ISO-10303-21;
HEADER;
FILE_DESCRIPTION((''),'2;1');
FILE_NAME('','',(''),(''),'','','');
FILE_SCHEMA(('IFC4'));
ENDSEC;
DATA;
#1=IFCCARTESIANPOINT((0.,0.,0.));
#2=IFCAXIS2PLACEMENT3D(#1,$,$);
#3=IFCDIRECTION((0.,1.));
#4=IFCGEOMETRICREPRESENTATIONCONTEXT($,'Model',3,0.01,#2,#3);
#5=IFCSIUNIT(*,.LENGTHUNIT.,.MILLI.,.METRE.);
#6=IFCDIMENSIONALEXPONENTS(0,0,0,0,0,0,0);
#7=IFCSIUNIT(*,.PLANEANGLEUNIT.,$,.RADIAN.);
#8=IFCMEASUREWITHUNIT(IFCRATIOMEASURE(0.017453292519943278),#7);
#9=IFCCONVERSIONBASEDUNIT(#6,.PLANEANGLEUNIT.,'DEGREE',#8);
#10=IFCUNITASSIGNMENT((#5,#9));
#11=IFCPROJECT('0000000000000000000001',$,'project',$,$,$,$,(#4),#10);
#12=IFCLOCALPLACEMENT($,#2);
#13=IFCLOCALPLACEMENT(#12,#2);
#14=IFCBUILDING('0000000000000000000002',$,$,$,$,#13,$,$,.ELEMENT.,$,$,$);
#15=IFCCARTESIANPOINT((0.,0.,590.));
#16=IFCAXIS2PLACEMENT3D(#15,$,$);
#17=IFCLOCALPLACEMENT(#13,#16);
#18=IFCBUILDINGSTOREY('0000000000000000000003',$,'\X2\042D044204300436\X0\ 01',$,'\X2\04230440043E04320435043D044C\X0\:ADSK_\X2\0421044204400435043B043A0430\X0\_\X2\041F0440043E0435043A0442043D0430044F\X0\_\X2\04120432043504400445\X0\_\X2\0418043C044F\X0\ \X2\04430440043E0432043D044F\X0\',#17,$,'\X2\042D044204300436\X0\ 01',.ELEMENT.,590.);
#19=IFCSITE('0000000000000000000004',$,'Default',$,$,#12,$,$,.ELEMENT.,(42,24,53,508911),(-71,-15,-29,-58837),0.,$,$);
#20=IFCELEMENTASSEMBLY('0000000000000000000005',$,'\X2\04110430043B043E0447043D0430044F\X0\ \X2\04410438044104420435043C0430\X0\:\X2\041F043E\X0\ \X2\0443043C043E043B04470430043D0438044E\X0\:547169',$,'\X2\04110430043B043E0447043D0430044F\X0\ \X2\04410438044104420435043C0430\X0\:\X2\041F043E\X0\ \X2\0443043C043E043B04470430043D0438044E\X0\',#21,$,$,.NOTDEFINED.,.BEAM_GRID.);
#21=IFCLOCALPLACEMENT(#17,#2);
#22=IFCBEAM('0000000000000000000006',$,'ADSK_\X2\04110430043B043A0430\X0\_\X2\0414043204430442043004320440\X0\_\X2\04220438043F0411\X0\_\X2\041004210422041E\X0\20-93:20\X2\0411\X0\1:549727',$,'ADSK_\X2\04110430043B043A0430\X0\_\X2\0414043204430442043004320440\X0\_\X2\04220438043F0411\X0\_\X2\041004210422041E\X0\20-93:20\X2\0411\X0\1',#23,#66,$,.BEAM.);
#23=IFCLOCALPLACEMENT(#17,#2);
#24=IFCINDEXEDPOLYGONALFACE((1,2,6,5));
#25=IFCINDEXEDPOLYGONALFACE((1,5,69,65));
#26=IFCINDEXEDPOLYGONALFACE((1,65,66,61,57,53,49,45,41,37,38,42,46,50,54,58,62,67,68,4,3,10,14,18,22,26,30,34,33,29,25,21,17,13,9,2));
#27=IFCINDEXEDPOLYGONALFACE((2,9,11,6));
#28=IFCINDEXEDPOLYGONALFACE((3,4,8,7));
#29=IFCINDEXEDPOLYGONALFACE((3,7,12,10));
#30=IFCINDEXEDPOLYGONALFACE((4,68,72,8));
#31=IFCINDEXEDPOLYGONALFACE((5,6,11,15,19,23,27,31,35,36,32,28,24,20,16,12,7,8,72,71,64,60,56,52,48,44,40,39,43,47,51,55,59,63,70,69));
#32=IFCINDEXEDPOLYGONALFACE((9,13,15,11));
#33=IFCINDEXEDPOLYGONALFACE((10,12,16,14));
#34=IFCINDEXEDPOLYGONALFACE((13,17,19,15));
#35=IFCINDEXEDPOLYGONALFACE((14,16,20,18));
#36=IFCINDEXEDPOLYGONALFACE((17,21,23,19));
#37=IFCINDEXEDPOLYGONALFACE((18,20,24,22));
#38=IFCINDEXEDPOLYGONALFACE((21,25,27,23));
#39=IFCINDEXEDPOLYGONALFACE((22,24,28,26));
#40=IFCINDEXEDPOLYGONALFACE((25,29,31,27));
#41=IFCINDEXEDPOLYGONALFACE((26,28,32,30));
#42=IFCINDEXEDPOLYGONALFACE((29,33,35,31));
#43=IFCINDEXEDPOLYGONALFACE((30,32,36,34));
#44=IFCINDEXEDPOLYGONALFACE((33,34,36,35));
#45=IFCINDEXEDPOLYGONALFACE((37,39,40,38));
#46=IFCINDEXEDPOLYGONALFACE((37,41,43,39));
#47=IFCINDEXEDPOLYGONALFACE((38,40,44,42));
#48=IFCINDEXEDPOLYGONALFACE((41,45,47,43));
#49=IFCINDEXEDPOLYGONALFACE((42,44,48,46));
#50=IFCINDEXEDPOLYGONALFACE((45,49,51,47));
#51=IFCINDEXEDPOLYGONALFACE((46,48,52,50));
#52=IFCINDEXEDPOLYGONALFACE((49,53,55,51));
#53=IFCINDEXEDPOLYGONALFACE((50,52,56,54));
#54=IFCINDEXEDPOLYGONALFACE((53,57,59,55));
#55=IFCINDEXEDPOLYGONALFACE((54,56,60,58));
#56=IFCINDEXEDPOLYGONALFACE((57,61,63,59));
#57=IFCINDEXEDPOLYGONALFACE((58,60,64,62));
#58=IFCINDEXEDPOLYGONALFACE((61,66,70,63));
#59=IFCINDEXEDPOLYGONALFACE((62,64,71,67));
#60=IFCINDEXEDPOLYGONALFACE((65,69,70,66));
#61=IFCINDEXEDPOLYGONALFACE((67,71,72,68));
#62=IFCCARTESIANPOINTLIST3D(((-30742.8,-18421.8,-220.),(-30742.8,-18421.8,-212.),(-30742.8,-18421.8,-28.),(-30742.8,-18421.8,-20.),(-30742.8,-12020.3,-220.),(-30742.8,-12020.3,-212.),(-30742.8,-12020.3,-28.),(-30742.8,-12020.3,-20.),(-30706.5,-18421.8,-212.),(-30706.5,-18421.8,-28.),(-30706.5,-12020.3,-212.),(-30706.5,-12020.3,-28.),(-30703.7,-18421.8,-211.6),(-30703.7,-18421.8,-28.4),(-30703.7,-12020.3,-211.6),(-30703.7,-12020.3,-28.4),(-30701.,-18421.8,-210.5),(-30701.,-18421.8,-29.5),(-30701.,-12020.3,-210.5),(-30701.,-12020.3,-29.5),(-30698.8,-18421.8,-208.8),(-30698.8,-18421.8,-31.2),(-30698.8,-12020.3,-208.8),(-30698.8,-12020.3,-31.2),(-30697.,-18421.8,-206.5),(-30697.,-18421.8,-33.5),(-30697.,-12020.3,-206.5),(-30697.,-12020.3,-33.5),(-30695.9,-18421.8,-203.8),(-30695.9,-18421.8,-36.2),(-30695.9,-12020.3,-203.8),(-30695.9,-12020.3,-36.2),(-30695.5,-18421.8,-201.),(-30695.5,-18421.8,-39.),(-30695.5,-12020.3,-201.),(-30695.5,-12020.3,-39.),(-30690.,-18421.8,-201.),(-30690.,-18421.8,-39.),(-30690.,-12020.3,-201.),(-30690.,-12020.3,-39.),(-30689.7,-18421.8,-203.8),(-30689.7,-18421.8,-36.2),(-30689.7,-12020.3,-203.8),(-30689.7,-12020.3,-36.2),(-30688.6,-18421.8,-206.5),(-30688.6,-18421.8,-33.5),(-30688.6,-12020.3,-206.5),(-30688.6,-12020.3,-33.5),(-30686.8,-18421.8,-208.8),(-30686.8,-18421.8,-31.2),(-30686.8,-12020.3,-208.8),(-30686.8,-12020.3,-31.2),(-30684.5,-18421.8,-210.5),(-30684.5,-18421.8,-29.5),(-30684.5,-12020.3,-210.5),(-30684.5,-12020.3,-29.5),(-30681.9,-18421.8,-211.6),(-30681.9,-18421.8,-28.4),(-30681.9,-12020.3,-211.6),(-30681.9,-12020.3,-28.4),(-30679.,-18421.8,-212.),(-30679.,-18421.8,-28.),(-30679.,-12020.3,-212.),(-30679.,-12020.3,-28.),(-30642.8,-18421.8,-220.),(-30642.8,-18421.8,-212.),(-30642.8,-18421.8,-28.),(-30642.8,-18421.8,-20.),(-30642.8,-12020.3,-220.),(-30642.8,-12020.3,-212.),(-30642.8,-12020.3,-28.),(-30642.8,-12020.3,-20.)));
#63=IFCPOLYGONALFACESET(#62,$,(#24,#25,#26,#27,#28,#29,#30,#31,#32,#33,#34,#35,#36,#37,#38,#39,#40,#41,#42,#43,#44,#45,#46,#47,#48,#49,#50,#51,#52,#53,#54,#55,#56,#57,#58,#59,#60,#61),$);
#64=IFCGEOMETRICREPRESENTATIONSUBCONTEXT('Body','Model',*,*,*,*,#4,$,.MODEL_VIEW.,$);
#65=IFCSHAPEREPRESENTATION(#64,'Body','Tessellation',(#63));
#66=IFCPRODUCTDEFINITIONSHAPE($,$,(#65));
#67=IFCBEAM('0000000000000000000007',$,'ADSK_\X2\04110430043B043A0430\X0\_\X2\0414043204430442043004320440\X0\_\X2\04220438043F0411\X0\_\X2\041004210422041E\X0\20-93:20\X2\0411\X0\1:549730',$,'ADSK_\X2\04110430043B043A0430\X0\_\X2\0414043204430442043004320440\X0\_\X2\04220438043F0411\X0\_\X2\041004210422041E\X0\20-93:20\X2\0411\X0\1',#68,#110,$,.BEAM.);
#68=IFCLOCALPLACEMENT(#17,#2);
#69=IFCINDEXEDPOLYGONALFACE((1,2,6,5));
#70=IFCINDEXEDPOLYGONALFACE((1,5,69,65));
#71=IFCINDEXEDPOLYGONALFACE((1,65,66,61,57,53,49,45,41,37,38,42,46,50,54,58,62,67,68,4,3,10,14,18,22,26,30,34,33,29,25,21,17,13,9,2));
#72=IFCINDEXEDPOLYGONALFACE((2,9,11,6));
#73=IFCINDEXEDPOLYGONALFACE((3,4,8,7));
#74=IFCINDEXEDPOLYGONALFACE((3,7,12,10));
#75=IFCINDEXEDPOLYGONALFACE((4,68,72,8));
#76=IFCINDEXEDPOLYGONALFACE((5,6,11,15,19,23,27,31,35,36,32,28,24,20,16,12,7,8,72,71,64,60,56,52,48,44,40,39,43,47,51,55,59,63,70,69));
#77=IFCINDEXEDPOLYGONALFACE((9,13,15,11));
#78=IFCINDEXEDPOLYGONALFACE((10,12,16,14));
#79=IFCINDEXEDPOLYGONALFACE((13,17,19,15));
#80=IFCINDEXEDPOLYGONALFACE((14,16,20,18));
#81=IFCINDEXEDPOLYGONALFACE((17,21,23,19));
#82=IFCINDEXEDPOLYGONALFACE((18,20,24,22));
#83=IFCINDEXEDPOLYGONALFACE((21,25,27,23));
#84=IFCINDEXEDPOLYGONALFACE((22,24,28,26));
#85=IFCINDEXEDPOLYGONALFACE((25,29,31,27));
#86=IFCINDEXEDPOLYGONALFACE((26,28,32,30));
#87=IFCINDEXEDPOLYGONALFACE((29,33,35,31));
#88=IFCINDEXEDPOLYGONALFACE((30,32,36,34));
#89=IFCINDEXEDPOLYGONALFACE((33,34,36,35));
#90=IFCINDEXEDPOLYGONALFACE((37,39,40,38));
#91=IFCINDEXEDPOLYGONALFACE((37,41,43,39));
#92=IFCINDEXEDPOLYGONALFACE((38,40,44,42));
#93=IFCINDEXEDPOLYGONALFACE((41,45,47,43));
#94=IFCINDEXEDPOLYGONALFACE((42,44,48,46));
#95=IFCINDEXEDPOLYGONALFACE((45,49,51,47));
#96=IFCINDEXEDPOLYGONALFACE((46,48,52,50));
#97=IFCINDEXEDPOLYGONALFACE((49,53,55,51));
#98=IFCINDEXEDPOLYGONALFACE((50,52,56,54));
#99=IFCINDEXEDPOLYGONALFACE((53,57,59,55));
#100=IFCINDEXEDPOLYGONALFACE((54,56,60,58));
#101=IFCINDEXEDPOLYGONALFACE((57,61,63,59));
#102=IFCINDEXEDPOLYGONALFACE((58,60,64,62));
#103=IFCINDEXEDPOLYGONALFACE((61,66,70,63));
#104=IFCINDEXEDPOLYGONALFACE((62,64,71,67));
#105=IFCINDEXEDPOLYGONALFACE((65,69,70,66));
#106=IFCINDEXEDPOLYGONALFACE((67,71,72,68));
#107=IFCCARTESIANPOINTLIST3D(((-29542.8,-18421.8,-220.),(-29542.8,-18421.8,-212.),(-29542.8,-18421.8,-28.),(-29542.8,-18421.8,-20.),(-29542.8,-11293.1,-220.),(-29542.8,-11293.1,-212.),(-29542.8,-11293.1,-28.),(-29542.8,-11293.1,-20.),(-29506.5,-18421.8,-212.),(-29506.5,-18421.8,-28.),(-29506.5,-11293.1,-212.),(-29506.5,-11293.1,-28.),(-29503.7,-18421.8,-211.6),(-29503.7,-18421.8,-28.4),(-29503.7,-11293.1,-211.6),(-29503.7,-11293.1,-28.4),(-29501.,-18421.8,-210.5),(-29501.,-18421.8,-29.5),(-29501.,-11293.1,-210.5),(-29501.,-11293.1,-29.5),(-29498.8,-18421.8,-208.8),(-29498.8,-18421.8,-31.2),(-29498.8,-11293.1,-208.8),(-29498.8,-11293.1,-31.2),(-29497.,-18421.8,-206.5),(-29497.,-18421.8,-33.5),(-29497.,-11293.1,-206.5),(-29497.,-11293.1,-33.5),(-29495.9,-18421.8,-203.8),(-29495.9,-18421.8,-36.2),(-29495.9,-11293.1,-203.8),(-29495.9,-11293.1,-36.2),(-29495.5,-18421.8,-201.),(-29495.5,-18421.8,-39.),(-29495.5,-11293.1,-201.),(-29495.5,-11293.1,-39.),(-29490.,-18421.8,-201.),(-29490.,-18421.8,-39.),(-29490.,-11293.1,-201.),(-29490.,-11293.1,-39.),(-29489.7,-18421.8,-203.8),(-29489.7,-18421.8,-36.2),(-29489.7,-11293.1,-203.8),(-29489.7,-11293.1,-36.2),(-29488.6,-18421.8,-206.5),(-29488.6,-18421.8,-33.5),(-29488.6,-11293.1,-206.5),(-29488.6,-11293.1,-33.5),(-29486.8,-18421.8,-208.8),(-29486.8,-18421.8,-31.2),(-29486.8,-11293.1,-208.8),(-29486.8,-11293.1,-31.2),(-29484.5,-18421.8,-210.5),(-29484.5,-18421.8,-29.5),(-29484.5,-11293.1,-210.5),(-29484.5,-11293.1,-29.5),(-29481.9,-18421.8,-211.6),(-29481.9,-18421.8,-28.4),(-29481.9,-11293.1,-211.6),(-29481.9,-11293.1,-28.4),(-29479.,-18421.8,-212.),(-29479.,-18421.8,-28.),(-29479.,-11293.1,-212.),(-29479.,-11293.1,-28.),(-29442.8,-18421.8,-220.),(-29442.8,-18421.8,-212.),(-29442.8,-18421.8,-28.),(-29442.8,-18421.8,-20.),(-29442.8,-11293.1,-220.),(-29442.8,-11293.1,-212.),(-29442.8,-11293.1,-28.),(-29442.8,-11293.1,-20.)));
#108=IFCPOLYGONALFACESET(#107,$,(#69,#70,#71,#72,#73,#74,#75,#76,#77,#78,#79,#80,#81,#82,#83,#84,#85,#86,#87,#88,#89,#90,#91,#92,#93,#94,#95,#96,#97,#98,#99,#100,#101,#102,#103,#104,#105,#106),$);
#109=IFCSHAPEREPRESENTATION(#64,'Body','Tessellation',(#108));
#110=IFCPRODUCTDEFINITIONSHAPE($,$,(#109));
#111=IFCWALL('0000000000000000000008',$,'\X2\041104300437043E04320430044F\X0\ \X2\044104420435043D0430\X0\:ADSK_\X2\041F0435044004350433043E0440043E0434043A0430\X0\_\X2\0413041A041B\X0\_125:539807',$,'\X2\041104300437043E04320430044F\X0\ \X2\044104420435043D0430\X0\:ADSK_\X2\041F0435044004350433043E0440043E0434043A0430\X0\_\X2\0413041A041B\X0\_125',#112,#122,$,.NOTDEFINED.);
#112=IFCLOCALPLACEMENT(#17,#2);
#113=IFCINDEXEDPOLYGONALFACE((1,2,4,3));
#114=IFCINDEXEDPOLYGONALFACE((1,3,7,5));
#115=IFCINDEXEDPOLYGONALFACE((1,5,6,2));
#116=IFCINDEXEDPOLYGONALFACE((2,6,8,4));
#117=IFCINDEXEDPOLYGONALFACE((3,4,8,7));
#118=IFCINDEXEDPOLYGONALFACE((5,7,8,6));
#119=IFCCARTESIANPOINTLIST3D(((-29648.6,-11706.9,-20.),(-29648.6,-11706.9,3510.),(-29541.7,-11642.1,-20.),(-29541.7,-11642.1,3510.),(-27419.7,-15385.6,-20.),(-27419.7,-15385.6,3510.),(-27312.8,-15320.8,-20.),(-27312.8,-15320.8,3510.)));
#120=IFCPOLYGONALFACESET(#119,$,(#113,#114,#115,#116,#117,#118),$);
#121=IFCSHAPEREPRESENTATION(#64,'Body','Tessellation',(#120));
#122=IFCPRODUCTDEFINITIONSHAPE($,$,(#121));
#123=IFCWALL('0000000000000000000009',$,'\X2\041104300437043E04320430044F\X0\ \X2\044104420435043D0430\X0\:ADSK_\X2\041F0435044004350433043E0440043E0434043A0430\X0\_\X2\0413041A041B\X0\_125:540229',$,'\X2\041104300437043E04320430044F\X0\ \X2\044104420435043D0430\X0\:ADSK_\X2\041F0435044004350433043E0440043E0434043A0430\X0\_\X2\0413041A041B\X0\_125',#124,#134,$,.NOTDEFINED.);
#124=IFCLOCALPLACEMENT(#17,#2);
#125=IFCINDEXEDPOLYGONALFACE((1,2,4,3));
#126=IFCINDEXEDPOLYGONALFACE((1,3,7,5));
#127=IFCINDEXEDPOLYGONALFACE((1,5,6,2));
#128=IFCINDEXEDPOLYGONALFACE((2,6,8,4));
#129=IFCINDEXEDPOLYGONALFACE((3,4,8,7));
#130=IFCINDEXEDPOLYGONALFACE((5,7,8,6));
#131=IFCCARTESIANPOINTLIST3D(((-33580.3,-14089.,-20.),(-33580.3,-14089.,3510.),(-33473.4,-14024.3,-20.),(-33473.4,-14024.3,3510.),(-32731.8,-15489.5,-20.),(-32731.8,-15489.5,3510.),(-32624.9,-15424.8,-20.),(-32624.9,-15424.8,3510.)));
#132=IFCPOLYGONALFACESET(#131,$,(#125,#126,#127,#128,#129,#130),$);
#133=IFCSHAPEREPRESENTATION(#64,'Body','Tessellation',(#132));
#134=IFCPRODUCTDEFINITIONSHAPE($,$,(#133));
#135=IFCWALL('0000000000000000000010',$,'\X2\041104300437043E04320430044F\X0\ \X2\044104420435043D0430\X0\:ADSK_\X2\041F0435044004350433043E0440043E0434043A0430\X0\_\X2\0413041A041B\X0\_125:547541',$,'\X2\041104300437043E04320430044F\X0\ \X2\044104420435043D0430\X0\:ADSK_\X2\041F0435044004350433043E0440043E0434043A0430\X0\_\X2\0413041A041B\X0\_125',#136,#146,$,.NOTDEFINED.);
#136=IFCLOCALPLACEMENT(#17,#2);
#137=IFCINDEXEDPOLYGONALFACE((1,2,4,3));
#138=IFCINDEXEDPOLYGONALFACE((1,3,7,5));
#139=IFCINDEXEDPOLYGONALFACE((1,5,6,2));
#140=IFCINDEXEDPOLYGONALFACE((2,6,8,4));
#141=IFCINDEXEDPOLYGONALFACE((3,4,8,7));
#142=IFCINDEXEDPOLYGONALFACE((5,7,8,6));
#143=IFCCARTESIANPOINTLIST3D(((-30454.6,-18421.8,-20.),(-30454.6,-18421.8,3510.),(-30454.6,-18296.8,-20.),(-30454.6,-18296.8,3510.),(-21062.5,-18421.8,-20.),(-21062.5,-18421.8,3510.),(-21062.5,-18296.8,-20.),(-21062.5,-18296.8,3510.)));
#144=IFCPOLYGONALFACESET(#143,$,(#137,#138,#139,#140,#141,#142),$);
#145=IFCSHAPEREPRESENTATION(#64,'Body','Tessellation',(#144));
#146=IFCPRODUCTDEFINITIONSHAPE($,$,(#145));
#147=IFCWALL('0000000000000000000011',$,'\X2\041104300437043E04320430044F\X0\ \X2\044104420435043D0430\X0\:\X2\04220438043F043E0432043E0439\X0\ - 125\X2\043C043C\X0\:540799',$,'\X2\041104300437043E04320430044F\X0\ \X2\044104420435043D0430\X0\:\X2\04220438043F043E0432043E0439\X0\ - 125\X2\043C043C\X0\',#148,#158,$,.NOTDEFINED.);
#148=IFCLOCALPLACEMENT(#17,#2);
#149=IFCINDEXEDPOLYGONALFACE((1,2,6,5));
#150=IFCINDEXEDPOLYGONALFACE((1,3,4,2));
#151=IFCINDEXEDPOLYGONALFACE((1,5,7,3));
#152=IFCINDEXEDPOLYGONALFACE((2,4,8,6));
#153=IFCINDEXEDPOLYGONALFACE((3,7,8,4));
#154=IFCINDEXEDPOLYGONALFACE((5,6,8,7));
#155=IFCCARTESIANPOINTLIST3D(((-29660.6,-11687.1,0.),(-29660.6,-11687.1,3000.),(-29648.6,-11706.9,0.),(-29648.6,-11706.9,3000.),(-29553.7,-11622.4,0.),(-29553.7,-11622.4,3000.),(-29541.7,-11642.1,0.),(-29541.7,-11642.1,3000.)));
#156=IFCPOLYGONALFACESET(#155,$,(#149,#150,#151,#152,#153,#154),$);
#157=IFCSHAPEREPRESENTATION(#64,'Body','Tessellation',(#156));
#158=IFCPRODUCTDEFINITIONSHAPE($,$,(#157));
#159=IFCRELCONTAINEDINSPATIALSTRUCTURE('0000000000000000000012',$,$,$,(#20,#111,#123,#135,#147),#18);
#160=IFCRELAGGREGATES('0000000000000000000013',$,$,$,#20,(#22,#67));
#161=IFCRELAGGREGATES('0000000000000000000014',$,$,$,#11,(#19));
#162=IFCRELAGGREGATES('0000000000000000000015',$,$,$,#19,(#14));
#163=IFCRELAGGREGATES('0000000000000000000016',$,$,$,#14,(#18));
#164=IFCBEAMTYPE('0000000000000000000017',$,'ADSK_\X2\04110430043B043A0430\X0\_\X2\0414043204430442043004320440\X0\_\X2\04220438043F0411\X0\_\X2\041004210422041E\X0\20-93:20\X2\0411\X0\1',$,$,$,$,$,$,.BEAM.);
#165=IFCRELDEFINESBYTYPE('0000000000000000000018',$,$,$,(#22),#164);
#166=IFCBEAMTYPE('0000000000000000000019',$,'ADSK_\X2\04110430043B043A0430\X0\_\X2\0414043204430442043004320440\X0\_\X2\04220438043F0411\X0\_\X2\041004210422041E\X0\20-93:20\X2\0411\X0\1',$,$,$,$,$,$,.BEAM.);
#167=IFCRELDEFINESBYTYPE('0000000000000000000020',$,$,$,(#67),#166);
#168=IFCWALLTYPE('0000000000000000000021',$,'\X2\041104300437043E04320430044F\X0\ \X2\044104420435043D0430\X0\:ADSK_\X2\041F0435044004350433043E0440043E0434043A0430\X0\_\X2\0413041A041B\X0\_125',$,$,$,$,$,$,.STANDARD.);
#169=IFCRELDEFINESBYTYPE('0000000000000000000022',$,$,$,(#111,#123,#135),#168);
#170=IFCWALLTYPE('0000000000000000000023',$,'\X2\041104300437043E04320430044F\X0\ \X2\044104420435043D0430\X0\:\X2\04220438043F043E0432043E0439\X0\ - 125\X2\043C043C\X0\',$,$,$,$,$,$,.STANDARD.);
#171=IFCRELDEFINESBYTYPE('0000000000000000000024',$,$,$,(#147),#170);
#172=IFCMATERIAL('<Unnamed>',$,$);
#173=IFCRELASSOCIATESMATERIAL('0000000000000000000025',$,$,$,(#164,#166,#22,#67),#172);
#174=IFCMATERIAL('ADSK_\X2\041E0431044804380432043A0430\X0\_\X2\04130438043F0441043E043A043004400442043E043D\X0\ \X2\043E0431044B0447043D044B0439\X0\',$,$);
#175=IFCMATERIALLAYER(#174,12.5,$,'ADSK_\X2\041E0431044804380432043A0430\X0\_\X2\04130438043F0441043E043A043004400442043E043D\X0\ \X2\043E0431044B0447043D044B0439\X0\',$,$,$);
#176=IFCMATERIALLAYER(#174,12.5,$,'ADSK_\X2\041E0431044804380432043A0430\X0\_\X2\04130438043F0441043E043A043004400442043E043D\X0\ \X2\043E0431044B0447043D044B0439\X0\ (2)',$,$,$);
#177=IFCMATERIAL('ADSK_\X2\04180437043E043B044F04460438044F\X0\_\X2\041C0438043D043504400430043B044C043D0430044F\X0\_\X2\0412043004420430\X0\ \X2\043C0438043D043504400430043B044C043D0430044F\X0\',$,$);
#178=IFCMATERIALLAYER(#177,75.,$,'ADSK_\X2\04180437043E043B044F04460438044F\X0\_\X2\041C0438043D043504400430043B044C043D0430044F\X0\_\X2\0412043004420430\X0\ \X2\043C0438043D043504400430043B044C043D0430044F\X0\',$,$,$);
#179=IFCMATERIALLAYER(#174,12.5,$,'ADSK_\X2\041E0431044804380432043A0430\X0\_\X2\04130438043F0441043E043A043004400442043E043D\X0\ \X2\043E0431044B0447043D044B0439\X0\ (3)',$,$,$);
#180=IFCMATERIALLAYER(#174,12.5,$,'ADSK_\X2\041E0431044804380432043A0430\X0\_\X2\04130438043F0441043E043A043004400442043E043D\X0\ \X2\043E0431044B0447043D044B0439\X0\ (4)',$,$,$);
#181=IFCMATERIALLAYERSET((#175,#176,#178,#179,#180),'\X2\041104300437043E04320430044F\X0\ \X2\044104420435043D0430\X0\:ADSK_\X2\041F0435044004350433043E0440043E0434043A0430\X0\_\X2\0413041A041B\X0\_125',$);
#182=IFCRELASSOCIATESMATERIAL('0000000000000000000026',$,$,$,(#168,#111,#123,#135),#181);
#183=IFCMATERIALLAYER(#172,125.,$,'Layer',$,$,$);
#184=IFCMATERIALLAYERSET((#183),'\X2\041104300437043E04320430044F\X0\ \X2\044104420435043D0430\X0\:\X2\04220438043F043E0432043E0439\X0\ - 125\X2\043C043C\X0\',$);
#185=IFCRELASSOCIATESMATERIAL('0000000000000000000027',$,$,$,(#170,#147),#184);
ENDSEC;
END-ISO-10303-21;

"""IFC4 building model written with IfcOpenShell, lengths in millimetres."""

from ifc_helpers import new_model, entity, si_unit, converted_unit, direction, frame, frame_2d, origin, place, context, subcontext, project, spatial, polyline, circle_curve, parameter, trimmed, segment, composite_curve, rectangle, i_section, outline, extrude, source, transform, mapped, material, layer, layer_set, layer_usage, material_profile, profile_set, profile_usage, type_object, type_shapes, element, aggregate, save


model = new_model("IFC4")

# Units and contexts
model_context = context("Model", 3, precision=0.01, world=origin(), true_north=direction((0.0, 1.0)))
body_context = subcontext(model_context, "Body", "Model", "MODEL_VIEW")
ifc_project = project(units=[si_unit("LENGTHUNIT", "METRE", prefix="MILLI"), converted_unit("PLANEANGLEUNIT", "DEGREE", entity("IfcRatioMeasure", 0.017453292519943278), si_unit("PLANEANGLEUNIT", "RADIAN"), dimensions=[0, 0, 0, 0, 0, 0, 0])], contexts=[model_context])

# Site, building, storey
site_placement = place(None, origin())
site = spatial("IfcSite", under=ifc_project, at=site_placement, Name="Default", CompositionType="ELEMENT", RefLatitude=(42, 24, 53, 508911), RefLongitude=(-71, -15, -29, -58837), RefElevation=0.0)
building_placement = place(site_placement, origin())
building = spatial("IfcBuilding", under=site, at=building_placement, CompositionType="ELEMENT")
storey_placement = place(building_placement, frame((0.0, 0.0, 590.0)))
storey = spatial("IfcBuildingStorey", under=building, at=storey_placement, Name="Этаж 01", ObjectType="Уровень:ADSK_Стрелка_Проектная_Вверх_Имя уровня", LongName="Этаж 01", CompositionType="ELEMENT", Elevation=590.0)

# Element assembly, beams
assembly_placement = place(storey_placement, origin())
assembly = element("IfcElementAssembly", 1, at=assembly_placement, inside=storey, Name="Балочная система:По умолчанию:547169", ObjectType="Балочная система:По умолчанию", AssemblyPlace="NOTDEFINED", PredefinedType="BEAM_GRID")
ifc_material_1 = material(Name="<Unnamed>")
ifc_material_profile = material_profile(ifc_material_1, outline(composite_curve([segment(polyline([(13.7, -192.0, 0.0), (50.0, -192.0, 0.0)]), True, "CONTINUOUS"), segment(polyline([(50.0, -192.0, 0.0), (50.0, -200.0, 0.0)]), True, "CONTINUOUS"), segment(polyline([(50.0, -200.0, 0.0), (-50.0, -200.0, 0.0)]), True, "CONTINUOUS"), segment(polyline([(-50.0, -200.0, 0.0), (-50.0, -192.0, 0.0)]), True, "CONTINUOUS"), segment(polyline([(-50.0, -192.0, 0.0), (-13.8, -192.0, 0.0)]), True, "CONTINUOUS"), segment(trimmed(circle_curve(frame((-13.8, -181.0, 0.0), z_axis=(0.0, 0.0, 1.0), x_axis=(-1.0, 0.0, 0.0)), 11.0), [parameter(90.0)], [parameter(180.0)], True, "PARAMETER"), True, "CONTINUOUS"), segment(polyline([(-2.8, -181.0, 0.0), (-2.8, -19.0, 0.0)]), True, "CONTINUOUS"), segment(trimmed(circle_curve(frame((-13.8, -19.0, 0.0), z_axis=(0.0, 0.0, 1.0), x_axis=(-1.0, 0.0, 0.0)), 11.0), [parameter(180.0)], [parameter(270.0)], True, "PARAMETER"), True, "CONTINUOUS"), segment(polyline([(-13.8, -8.0, 0.0), (-50.0, -8.0, 0.0)]), True, "CONTINUOUS"), segment(polyline([(-50.0, -8.0, 0.0), (-50.0, 0.0, 0.0)]), True, "CONTINUOUS"), segment(polyline([(-50.0, 0.0, 0.0), (50.0, 0.0, 0.0)]), True, "CONTINUOUS"), segment(polyline([(50.0, 0.0, 0.0), (50.0, -8.0, 0.0)]), True, "CONTINUOUS"), segment(polyline([(50.0, -8.0, 0.0), (13.7, -8.0, 0.0)]), True, "CONTINUOUS"), segment(trimmed(circle_curve(frame((13.7, -19.0, 0.0), z_axis=(0.0, 0.0, 1.0), x_axis=(-1.0, 0.0, 0.0)), 11.0), [parameter(270.0)], [parameter(0.0)], True, "PARAMETER"), True, "CONTINUOUS"), segment(polyline([(2.7, -19.0, 0.0), (2.7, -181.0, 0.0)]), True, "CONTINUOUS"), segment(trimmed(circle_curve(frame((13.7, -181.0, 0.0), z_axis=(0.0, 0.0, 1.0), x_axis=(-1.0, 0.0, 0.0)), 11.0), [parameter(0.0)], [parameter(90.0)], True, "PARAMETER"), True, "CONTINUOUS")], self_intersect=False), kind="CURVE"), Name="20Б1")
ifc_profile_set = profile_set([ifc_material_profile], Name="20Б1")
ifc_profile_usage_1 = profile_usage(ifc_profile_set, cardinal=8)
beam_type_1 = type_object("IfcBeamType", Name="ADSK_Балка_Двутавр_ТипБ_АСТО20-93:20Б1", PredefinedType="BEAM", material=ifc_profile_set)
shared_shape_1 = source(origin(), body_context, "Body", "SweptSolid", [
    extrude(i_section(OverallWidth=100.0, OverallDepth=200.0, WebThickness=5.5, FlangeThickness=8.0, FilletRadius=11.0, at=frame_2d((0.0, 0.0), x_axis=(0.0, 1.0))), frame((-3200.8, 0.0, -100.0), z_axis=(1.0, 0.0, 0.0), x_axis=(0.0, 0.0, -1.0)), (0.0, 0.0, 1.0), 6401.5),
])
type_shapes(beam_type_1, [shared_shape_1])
beam_1_placement = place(assembly_placement, frame((-30692.8, -15221.0, -20.0), z_axis=(0.0, 0.0, 1.0), x_axis=(0.0, 1.0, 0.0)))
beam_1 = element("IfcBeam", 2, at=beam_1_placement, type_object=beam_type_1, material=ifc_profile_usage_1, Name="ADSK_Балка_Двутавр_ТипБ_АСТО20-93:20Б1:549727", ObjectType="ADSK_Балка_Двутавр_ТипБ_АСТО20-93:20Б1", PredefinedType="BEAM", context=body_context, shape_type="MappedRepresentation", body=[
    mapped(shared_shape_1, transform((0.0, 0.0, 0.0), scale=1.0)),
])
ifc_profile_usage_2 = profile_usage(ifc_profile_set, cardinal=8)
beam_type_2 = type_object("IfcBeamType", Name="ADSK_Балка_Двутавр_ТипБ_АСТО20-93:20Б1", PredefinedType="BEAM", material=ifc_profile_set)
shared_shape_2 = source(origin(), body_context, "Body", "SweptSolid", [
    extrude(i_section(OverallWidth=100.0, OverallDepth=200.0, WebThickness=5.5, FlangeThickness=8.0, FilletRadius=11.0, at=frame_2d((0.0, 0.0), x_axis=(0.0, 1.0))), frame((-3564.3, 0.0, -100.0), z_axis=(1.0, 0.0, 0.0), x_axis=(0.0, 0.0, -1.0)), (0.0, 0.0, 1.0), 7128.7),
])
type_shapes(beam_type_2, [shared_shape_2])
beam_2_placement = place(assembly_placement, frame((-29492.8, -14857.5, -20.0), z_axis=(0.0, 0.0, 1.0), x_axis=(0.0, 1.0, 0.0)))
beam_2 = element("IfcBeam", 3, at=beam_2_placement, type_object=beam_type_2, material=ifc_profile_usage_2, Name="ADSK_Балка_Двутавр_ТипБ_АСТО20-93:20Б1:549730", ObjectType="ADSK_Балка_Двутавр_ТипБ_АСТО20-93:20Б1", PredefinedType="BEAM", context=body_context, shape_type="MappedRepresentation", body=[
    mapped(shared_shape_2, transform((0.0, 0.0, 0.0), scale=1.0)),
])
aggregate(assembly, [beam_1, beam_2])

# Walls
ifc_material_2 = material(Name="ADSK_Обшивка_Гипсокартон обычный")
ifc_layer_1 = layer(ifc_material_2, 12.5, Name="ADSK_Обшивка_Гипсокартон обычный")
ifc_layer_2 = layer(ifc_material_2, 12.5, Name="ADSK_Обшивка_Гипсокартон обычный (2)")
ifc_material_3 = material(Name="ADSK_Изоляция_Минеральная_Вата минеральная")
ifc_layer_3 = layer(ifc_material_3, 75.0, Name="ADSK_Изоляция_Минеральная_Вата минеральная")
ifc_layer_4 = layer(ifc_material_2, 12.5, Name="ADSK_Обшивка_Гипсокартон обычный (3)")
ifc_layer_5 = layer(ifc_material_2, 12.5, Name="ADSK_Обшивка_Гипсокартон обычный (4)")
ifc_layer_set_1 = layer_set([ifc_layer_1, ifc_layer_2, ifc_layer_3, ifc_layer_4, ifc_layer_5], Name="Базовая стена:ADSK_Перегородка_ГКЛ_125")
ifc_layer_usage_1 = layer_usage(ifc_layer_set_1, "AXIS2", "NEGATIVE", 62.5)
wall_type_1 = type_object("IfcWallType", Name="Базовая стена:ADSK_Перегородка_ГКЛ_125", PredefinedType="STANDARD", material=ifc_layer_set_1)
wall_1_placement = place(storey_placement, frame((-29595.1, -11674.5, -20.0), z_axis=(0.0, 0.0, 1.0), x_axis=(0.518188, -0.855267, 0.0)))
element("IfcWall", 4, at=wall_1_placement, inside=storey, type_object=wall_type_1, material=ifc_layer_usage_1, Name="Базовая стена:ADSK_Перегородка_ГКЛ_125:539807", ObjectType="Базовая стена:ADSK_Перегородка_ГКЛ_125", PredefinedType="NOTDEFINED", context=body_context, shape_type="SweptSolid", body=[
    extrude(rectangle(XDim=4301.2, YDim=125.0, at=frame_2d((2150.6, 0.0), x_axis=(-1.0, 0.0))), origin(), (0.0, 0.0, 1.0), 3530.0),
])
ifc_layer_usage_2 = layer_usage(ifc_layer_set_1, "AXIS2", "NEGATIVE", 62.5)
wall_2_placement = place(storey_placement, frame((-32678.3, -15457.1, -20.0), z_axis=(0.0, 0.0, 1.0), x_axis=(-0.518188, 0.855267, 0.0)))
element("IfcWall", 5, at=wall_2_placement, inside=storey, type_object=wall_type_1, material=ifc_layer_usage_2, Name="Базовая стена:ADSK_Перегородка_ГКЛ_125:540229", ObjectType="Базовая стена:ADSK_Перегородка_ГКЛ_125", PredefinedType="NOTDEFINED", context=body_context, shape_type="SweptSolid", body=[
    extrude(rectangle(XDim=1637.5, YDim=125.0, at=frame_2d((818.7, 0.0), x_axis=(-1.0, 0.0))), origin(), (0.0, 0.0, 1.0), 3530.0),
])
ifc_layer_usage_3 = layer_usage(ifc_layer_set_1, "AXIS2", "NEGATIVE", 62.5)
wall_3_placement = place(storey_placement, frame((-30454.6, -18359.3, -20.0)))
element("IfcWall", 6, at=wall_3_placement, inside=storey, type_object=wall_type_1, material=ifc_layer_usage_3, Name="Базовая стена:ADSK_Перегородка_ГКЛ_125:547541", ObjectType="Базовая стена:ADSK_Перегородка_ГКЛ_125", PredefinedType="NOTDEFINED", context=body_context, shape_type="SweptSolid", body=[
    extrude(rectangle(XDim=9392.2, YDim=125.0, at=frame_2d((4696.1, 0.0), x_axis=(-1.0, 0.0))), origin(), (0.0, 0.0, 1.0), 3530.0),
])
ifc_layer_6 = layer(ifc_material_1, 125.0, Name="Layer")
ifc_layer_set_2 = layer_set([ifc_layer_6], Name="Базовая стена:Типовой - 125мм")
ifc_layer_usage_4 = layer_usage(ifc_layer_set_2, "AXIS2", "NEGATIVE", 62.5)
wall_type_2 = type_object("IfcWallType", Name="Базовая стена:Типовой - 125мм", PredefinedType="STANDARD", material=ifc_layer_set_2)
wall_4_placement = place(storey_placement, frame((-29595.1, -11674.5, 0.0), z_axis=(0.0, 0.0, 1.0), x_axis=(-0.518188, 0.855267, 0.0)))
element("IfcWall", 7, at=wall_4_placement, inside=storey, type_object=wall_type_2, material=ifc_layer_usage_4, Name="Базовая стена:Типовой - 125мм:540799", ObjectType="Базовая стена:Типовой - 125мм", PredefinedType="NOTDEFINED", context=body_context, shape_type="SweptSolid", body=[
    extrude(rectangle(XDim=23.1, YDim=125.0, at=frame_2d((11.6, 0.0), x_axis=(-1.0, 0.0))), origin(), (0.0, 0.0, 1.0), 3000.0),
])

save(model, "model.ifc")
